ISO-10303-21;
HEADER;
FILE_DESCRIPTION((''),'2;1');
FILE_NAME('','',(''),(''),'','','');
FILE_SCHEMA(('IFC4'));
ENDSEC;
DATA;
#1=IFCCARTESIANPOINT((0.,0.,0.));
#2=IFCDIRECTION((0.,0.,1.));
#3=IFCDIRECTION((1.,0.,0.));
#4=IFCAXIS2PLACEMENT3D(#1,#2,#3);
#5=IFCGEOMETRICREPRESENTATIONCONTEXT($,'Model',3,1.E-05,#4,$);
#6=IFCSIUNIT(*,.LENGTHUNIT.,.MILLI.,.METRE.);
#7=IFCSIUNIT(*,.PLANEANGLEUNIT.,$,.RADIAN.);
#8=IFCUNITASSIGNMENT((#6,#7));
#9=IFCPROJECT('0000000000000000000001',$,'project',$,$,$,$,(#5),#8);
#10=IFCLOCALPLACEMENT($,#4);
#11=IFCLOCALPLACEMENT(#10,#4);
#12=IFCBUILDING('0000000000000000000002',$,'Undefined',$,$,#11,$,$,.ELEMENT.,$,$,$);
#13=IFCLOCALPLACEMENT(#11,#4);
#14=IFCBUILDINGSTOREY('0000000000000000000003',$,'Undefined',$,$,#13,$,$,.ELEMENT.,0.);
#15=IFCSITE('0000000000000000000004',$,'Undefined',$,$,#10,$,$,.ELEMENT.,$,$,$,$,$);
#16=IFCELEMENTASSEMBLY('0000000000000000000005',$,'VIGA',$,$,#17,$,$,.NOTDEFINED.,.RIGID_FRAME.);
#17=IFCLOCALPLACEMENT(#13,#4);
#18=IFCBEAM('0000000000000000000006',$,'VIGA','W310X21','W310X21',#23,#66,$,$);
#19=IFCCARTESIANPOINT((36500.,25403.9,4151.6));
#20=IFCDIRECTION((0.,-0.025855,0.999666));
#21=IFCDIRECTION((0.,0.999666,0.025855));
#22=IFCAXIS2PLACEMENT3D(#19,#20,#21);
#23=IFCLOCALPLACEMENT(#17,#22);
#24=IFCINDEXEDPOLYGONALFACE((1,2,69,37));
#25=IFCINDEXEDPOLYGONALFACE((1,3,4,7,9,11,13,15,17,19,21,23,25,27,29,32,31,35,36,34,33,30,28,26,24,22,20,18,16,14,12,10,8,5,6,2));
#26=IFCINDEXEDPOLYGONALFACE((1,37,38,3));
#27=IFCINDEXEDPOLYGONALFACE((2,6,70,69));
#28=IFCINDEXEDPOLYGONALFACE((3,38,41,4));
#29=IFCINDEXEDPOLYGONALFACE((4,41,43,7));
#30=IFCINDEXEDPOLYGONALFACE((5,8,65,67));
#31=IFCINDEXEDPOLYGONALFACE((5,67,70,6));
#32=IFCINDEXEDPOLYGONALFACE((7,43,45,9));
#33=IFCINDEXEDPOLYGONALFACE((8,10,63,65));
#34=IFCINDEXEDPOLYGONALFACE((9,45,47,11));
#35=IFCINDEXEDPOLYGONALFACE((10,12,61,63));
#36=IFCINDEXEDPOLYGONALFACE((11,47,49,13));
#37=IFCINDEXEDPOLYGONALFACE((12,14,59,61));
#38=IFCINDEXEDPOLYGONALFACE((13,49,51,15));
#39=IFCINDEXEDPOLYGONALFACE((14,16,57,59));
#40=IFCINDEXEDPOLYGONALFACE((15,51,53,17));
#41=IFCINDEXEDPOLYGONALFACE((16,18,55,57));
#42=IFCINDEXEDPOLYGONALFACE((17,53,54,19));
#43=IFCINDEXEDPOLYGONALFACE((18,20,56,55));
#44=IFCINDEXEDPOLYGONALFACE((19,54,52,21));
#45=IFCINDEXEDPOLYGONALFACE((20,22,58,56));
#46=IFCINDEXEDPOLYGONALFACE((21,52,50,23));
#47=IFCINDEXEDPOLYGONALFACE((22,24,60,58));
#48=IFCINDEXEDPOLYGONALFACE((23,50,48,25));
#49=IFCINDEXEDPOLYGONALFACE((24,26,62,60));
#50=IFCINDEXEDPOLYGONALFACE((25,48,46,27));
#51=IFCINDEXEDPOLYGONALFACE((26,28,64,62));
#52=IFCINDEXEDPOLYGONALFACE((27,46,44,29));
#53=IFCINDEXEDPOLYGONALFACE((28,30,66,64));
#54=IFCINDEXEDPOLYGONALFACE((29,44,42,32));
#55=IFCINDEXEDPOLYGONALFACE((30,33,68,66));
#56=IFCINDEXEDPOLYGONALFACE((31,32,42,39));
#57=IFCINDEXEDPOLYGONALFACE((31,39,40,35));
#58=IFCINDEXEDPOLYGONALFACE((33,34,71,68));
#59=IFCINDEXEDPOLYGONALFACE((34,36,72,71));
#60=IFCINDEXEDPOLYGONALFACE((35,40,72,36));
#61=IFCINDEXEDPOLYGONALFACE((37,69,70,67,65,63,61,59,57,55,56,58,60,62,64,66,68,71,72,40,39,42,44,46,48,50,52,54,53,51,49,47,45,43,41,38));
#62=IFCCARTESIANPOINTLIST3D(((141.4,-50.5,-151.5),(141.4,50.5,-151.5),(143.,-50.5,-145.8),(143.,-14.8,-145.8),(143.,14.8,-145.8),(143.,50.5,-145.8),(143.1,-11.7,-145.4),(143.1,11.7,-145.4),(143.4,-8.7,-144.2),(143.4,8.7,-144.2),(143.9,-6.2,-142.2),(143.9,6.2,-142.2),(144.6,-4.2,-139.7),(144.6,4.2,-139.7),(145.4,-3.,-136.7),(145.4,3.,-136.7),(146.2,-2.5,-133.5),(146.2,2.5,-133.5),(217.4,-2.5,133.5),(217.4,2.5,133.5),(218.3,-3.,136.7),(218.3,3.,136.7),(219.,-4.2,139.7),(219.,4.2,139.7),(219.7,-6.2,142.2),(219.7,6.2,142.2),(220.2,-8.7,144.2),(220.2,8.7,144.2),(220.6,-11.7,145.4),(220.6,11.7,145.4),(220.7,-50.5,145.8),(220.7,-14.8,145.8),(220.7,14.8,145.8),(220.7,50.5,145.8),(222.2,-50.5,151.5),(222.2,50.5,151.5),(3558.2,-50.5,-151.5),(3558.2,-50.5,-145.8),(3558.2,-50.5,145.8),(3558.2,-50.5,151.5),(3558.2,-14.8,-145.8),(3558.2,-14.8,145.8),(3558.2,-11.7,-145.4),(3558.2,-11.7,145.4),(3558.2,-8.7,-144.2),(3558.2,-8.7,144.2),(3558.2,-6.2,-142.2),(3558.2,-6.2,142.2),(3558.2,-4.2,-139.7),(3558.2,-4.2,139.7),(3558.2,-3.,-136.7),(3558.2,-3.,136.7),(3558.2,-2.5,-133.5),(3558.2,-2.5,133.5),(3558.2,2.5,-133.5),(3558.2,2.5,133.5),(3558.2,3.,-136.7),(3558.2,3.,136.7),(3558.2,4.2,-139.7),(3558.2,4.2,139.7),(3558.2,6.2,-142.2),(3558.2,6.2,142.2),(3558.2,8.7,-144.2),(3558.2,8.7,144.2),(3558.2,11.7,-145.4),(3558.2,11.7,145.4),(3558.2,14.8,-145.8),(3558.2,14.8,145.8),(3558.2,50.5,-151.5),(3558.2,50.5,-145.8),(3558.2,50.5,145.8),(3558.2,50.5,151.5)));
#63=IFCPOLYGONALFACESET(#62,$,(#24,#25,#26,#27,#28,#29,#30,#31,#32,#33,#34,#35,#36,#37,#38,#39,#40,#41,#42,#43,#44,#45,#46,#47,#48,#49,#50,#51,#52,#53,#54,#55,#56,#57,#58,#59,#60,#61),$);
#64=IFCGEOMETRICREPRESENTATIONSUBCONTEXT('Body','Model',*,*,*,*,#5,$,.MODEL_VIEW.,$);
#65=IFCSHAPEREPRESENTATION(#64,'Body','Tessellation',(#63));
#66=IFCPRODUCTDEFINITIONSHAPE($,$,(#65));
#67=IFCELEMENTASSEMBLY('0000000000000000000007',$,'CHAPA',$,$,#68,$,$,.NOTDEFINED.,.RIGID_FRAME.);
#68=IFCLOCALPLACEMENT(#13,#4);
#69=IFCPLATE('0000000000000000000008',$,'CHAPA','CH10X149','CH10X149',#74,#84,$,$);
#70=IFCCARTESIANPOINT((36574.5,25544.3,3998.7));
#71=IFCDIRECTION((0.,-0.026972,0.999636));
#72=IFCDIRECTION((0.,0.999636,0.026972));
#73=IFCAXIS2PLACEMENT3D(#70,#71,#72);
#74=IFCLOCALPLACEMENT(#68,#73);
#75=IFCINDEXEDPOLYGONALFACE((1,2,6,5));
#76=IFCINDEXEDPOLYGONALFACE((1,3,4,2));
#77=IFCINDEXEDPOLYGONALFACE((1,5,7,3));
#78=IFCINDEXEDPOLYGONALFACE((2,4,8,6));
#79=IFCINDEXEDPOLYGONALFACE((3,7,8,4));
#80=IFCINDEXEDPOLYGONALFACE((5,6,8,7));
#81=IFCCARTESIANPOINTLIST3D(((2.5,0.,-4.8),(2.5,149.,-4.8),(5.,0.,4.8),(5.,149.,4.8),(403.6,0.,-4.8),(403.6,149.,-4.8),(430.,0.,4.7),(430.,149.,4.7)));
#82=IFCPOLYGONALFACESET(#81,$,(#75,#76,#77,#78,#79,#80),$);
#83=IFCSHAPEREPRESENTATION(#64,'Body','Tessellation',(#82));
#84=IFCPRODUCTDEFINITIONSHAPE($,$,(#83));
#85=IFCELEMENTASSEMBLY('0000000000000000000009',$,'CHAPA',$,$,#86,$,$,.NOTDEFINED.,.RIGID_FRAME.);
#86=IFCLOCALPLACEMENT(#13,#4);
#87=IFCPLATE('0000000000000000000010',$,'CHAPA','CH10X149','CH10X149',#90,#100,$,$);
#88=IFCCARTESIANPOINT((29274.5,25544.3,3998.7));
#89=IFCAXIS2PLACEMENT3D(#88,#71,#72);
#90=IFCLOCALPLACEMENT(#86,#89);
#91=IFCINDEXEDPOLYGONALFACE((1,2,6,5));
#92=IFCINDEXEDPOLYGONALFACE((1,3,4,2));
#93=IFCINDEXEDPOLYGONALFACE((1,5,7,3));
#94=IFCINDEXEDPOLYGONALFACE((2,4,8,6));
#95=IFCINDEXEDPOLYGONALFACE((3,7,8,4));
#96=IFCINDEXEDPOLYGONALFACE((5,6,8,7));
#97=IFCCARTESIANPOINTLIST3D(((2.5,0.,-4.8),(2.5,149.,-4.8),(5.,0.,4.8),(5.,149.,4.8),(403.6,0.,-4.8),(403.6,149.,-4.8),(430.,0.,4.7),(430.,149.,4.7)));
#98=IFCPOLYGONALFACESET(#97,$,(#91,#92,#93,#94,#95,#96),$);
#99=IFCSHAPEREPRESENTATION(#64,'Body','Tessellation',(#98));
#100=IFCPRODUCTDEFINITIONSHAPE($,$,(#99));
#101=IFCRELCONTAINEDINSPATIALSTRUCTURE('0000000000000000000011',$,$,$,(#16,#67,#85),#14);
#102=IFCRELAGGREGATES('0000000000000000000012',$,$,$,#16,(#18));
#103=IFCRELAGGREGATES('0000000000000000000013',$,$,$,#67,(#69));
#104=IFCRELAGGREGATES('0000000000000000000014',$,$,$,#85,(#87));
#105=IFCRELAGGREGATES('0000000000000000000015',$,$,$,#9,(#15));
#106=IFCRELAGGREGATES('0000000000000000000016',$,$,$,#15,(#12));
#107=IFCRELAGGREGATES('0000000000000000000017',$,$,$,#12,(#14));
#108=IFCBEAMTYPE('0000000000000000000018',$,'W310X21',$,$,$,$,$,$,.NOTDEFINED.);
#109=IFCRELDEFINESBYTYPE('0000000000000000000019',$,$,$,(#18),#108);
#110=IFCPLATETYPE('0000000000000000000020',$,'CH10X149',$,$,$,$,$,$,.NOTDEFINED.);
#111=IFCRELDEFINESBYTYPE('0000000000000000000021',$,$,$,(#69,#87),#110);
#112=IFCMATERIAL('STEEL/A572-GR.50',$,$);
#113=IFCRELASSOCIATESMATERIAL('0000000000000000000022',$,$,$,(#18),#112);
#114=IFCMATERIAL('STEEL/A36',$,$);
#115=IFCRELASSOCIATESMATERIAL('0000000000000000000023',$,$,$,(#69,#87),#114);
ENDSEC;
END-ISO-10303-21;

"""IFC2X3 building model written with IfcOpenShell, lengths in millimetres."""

from ifc_helpers import new_model, si_unit, frame, origin_with_axes, origin_2d_with_axis, place, context, subcontext, project, spatial, polyline, i_section, outline, extrude, clip, halfspace, material, type_object, element, aggregate, save


model = new_model("IFC2X3")

# Units and contexts
model_context = context("Model", 3, precision=1e-05, world=origin_with_axes())
body_context = subcontext(model_context, "Body", "Model", "MODEL_VIEW")
ifc_project = project(units=[si_unit("LENGTHUNIT", "METRE", prefix="MILLI"), si_unit("PLANEANGLEUNIT", "RADIAN")], contexts=[model_context])

# Site, building, storey
site_placement = place(None, origin_with_axes())
site = spatial("IfcSite", under=ifc_project, at=site_placement, Name="Undefined", CompositionType="ELEMENT")
building_placement = place(site_placement, origin_with_axes())
building = spatial("IfcBuilding", under=site, at=building_placement, Name="Undefined", CompositionType="ELEMENT")
storey_placement = place(building_placement, origin_with_axes())
storey = spatial("IfcBuildingStorey", under=building, at=storey_placement, Name="Undefined", CompositionType="ELEMENT", Elevation=0.0)

# Element assembly, beam
ifc_material_1 = material(Name="STEEL/A36")
ifc_material_2 = material(Name="STEEL/A572-GR.50")
assembly_1_placement = place(storey_placement, origin_with_axes())
assembly_1 = element("IfcElementAssembly", 1, at=assembly_1_placement, inside=storey, Name="VIGA", AssemblyPlace="NOTDEFINED", PredefinedType="RIGID_FRAME")
beam_type_1 = type_object("IfcBeamType", Name="W310X21", PredefinedType="NOTDEFINED")
beam_1_placement = place(assembly_1_placement, frame((36500.0, 25403.9, 4151.6), z_axis=(0.0, -0.025855, 0.999666), x_axis=(0.0, 0.999666, 0.025855)))
beam_1 = element("IfcBeam", 2, at=beam_1_placement, type_object=beam_type_1, material=ifc_material_2, Name="VIGA", Description="W310X21", ObjectType="W310X21", context=body_context, shape_type="Clipping", body=[
    clip(extrude(i_section(OverallWidth=101.0, OverallDepth=303.0, WebThickness=5.1, FlangeThickness=5.7, FilletRadius=12.3, at=origin_2d_with_axis()), frame((3558.2, 0.0, 0.0), z_axis=(-1.0, 0.0, 0.0), x_axis=(0.0, -1.0, 0.0)), (0.0, 0.0, 1.0), 3558.2), halfspace(frame((141.4, -50.5, -151.7), z_axis=(-0.966259, 0.0, 0.257573), x_axis=(0.0, 1.0, 0.0)), False)),
])
aggregate(assembly_1, [beam_1])

# Element assemblies, plates
plate_type_1 = type_object("IfcPlateType", Name="CH10X149", PredefinedType="NOTDEFINED")
assembly_2_placement = place(storey_placement, origin_with_axes())
assembly_2 = element("IfcElementAssembly", 3, at=assembly_2_placement, inside=storey, Name="CHAPA", AssemblyPlace="NOTDEFINED", PredefinedType="RIGID_FRAME")
plate_1_placement = place(assembly_2_placement, frame((36574.5, 25544.3, 3998.7), z_axis=(0.0, -0.026972, 0.999636), x_axis=(0.0, 0.999636, 0.026972)))
plate_1 = element("IfcPlate", 4, at=plate_1_placement, type_object=plate_type_1, material=ifc_material_1, Name="CHAPA", Description="CH10X149", ObjectType="CH10X149", context=body_context, shape_type="Clipping", body=[
    clip(clip(extrude(outline(polyline([(0.0, 0.0), (430.0, 0.0), (430.0, 149.0), (0.0, 149.0), (0.0, 0.0)])), frame((0.0, 0.0, -4.8), z_axis=(0.0, 0.0, 1.0), x_axis=(1.0, 0.0, 0.0)), (0.0, 0.0, 1.0), 9.5), halfspace(frame((403.6, -500.0, -4.8), z_axis=(0.33881, 0.0, -0.940855), x_axis=(0.940855, 0.0, 0.33881)), False)), halfspace(frame((5.0, -500.0, 4.7), z_axis=(-0.965989, 0.0, 0.258583), x_axis=(-0.258583, 0.0, -0.965989)), False)),
])
aggregate(assembly_2, [plate_1])
assembly_3_placement = place(storey_placement, origin_with_axes())
assembly_3 = element("IfcElementAssembly", 5, at=assembly_3_placement, inside=storey, Name="CHAPA", AssemblyPlace="NOTDEFINED", PredefinedType="RIGID_FRAME")
plate_2_placement = place(assembly_3_placement, frame((29274.5, 25544.3, 3998.7), z_axis=(0.0, -0.026972, 0.999636), x_axis=(0.0, 0.999636, 0.026972)))
plate_2 = element("IfcPlate", 6, at=plate_2_placement, type_object=plate_type_1, material=ifc_material_1, Name="CHAPA", Description="CH10X149", ObjectType="CH10X149", context=body_context, shape_type="Clipping", body=[
    clip(clip(extrude(outline(polyline([(0.0, 0.0), (430.0, 0.0), (430.0, 149.0), (0.0, 149.0), (0.0, 0.0)])), frame((0.0, 0.0, -4.8), z_axis=(0.0, 0.0, 1.0), x_axis=(1.0, 0.0, 0.0)), (0.0, 0.0, 1.0), 9.5), halfspace(frame((403.6, -500.0, -4.8), z_axis=(0.33881, 0.0, -0.940855), x_axis=(0.940855, 0.0, 0.33881)), False)), halfspace(frame((5.0, -500.0, 4.7), z_axis=(-0.965989, 0.0, 0.258583), x_axis=(-0.258583, 0.0, -0.965989)), False)),
])
aggregate(assembly_3, [plate_2])

save(model, "model.ifc")
